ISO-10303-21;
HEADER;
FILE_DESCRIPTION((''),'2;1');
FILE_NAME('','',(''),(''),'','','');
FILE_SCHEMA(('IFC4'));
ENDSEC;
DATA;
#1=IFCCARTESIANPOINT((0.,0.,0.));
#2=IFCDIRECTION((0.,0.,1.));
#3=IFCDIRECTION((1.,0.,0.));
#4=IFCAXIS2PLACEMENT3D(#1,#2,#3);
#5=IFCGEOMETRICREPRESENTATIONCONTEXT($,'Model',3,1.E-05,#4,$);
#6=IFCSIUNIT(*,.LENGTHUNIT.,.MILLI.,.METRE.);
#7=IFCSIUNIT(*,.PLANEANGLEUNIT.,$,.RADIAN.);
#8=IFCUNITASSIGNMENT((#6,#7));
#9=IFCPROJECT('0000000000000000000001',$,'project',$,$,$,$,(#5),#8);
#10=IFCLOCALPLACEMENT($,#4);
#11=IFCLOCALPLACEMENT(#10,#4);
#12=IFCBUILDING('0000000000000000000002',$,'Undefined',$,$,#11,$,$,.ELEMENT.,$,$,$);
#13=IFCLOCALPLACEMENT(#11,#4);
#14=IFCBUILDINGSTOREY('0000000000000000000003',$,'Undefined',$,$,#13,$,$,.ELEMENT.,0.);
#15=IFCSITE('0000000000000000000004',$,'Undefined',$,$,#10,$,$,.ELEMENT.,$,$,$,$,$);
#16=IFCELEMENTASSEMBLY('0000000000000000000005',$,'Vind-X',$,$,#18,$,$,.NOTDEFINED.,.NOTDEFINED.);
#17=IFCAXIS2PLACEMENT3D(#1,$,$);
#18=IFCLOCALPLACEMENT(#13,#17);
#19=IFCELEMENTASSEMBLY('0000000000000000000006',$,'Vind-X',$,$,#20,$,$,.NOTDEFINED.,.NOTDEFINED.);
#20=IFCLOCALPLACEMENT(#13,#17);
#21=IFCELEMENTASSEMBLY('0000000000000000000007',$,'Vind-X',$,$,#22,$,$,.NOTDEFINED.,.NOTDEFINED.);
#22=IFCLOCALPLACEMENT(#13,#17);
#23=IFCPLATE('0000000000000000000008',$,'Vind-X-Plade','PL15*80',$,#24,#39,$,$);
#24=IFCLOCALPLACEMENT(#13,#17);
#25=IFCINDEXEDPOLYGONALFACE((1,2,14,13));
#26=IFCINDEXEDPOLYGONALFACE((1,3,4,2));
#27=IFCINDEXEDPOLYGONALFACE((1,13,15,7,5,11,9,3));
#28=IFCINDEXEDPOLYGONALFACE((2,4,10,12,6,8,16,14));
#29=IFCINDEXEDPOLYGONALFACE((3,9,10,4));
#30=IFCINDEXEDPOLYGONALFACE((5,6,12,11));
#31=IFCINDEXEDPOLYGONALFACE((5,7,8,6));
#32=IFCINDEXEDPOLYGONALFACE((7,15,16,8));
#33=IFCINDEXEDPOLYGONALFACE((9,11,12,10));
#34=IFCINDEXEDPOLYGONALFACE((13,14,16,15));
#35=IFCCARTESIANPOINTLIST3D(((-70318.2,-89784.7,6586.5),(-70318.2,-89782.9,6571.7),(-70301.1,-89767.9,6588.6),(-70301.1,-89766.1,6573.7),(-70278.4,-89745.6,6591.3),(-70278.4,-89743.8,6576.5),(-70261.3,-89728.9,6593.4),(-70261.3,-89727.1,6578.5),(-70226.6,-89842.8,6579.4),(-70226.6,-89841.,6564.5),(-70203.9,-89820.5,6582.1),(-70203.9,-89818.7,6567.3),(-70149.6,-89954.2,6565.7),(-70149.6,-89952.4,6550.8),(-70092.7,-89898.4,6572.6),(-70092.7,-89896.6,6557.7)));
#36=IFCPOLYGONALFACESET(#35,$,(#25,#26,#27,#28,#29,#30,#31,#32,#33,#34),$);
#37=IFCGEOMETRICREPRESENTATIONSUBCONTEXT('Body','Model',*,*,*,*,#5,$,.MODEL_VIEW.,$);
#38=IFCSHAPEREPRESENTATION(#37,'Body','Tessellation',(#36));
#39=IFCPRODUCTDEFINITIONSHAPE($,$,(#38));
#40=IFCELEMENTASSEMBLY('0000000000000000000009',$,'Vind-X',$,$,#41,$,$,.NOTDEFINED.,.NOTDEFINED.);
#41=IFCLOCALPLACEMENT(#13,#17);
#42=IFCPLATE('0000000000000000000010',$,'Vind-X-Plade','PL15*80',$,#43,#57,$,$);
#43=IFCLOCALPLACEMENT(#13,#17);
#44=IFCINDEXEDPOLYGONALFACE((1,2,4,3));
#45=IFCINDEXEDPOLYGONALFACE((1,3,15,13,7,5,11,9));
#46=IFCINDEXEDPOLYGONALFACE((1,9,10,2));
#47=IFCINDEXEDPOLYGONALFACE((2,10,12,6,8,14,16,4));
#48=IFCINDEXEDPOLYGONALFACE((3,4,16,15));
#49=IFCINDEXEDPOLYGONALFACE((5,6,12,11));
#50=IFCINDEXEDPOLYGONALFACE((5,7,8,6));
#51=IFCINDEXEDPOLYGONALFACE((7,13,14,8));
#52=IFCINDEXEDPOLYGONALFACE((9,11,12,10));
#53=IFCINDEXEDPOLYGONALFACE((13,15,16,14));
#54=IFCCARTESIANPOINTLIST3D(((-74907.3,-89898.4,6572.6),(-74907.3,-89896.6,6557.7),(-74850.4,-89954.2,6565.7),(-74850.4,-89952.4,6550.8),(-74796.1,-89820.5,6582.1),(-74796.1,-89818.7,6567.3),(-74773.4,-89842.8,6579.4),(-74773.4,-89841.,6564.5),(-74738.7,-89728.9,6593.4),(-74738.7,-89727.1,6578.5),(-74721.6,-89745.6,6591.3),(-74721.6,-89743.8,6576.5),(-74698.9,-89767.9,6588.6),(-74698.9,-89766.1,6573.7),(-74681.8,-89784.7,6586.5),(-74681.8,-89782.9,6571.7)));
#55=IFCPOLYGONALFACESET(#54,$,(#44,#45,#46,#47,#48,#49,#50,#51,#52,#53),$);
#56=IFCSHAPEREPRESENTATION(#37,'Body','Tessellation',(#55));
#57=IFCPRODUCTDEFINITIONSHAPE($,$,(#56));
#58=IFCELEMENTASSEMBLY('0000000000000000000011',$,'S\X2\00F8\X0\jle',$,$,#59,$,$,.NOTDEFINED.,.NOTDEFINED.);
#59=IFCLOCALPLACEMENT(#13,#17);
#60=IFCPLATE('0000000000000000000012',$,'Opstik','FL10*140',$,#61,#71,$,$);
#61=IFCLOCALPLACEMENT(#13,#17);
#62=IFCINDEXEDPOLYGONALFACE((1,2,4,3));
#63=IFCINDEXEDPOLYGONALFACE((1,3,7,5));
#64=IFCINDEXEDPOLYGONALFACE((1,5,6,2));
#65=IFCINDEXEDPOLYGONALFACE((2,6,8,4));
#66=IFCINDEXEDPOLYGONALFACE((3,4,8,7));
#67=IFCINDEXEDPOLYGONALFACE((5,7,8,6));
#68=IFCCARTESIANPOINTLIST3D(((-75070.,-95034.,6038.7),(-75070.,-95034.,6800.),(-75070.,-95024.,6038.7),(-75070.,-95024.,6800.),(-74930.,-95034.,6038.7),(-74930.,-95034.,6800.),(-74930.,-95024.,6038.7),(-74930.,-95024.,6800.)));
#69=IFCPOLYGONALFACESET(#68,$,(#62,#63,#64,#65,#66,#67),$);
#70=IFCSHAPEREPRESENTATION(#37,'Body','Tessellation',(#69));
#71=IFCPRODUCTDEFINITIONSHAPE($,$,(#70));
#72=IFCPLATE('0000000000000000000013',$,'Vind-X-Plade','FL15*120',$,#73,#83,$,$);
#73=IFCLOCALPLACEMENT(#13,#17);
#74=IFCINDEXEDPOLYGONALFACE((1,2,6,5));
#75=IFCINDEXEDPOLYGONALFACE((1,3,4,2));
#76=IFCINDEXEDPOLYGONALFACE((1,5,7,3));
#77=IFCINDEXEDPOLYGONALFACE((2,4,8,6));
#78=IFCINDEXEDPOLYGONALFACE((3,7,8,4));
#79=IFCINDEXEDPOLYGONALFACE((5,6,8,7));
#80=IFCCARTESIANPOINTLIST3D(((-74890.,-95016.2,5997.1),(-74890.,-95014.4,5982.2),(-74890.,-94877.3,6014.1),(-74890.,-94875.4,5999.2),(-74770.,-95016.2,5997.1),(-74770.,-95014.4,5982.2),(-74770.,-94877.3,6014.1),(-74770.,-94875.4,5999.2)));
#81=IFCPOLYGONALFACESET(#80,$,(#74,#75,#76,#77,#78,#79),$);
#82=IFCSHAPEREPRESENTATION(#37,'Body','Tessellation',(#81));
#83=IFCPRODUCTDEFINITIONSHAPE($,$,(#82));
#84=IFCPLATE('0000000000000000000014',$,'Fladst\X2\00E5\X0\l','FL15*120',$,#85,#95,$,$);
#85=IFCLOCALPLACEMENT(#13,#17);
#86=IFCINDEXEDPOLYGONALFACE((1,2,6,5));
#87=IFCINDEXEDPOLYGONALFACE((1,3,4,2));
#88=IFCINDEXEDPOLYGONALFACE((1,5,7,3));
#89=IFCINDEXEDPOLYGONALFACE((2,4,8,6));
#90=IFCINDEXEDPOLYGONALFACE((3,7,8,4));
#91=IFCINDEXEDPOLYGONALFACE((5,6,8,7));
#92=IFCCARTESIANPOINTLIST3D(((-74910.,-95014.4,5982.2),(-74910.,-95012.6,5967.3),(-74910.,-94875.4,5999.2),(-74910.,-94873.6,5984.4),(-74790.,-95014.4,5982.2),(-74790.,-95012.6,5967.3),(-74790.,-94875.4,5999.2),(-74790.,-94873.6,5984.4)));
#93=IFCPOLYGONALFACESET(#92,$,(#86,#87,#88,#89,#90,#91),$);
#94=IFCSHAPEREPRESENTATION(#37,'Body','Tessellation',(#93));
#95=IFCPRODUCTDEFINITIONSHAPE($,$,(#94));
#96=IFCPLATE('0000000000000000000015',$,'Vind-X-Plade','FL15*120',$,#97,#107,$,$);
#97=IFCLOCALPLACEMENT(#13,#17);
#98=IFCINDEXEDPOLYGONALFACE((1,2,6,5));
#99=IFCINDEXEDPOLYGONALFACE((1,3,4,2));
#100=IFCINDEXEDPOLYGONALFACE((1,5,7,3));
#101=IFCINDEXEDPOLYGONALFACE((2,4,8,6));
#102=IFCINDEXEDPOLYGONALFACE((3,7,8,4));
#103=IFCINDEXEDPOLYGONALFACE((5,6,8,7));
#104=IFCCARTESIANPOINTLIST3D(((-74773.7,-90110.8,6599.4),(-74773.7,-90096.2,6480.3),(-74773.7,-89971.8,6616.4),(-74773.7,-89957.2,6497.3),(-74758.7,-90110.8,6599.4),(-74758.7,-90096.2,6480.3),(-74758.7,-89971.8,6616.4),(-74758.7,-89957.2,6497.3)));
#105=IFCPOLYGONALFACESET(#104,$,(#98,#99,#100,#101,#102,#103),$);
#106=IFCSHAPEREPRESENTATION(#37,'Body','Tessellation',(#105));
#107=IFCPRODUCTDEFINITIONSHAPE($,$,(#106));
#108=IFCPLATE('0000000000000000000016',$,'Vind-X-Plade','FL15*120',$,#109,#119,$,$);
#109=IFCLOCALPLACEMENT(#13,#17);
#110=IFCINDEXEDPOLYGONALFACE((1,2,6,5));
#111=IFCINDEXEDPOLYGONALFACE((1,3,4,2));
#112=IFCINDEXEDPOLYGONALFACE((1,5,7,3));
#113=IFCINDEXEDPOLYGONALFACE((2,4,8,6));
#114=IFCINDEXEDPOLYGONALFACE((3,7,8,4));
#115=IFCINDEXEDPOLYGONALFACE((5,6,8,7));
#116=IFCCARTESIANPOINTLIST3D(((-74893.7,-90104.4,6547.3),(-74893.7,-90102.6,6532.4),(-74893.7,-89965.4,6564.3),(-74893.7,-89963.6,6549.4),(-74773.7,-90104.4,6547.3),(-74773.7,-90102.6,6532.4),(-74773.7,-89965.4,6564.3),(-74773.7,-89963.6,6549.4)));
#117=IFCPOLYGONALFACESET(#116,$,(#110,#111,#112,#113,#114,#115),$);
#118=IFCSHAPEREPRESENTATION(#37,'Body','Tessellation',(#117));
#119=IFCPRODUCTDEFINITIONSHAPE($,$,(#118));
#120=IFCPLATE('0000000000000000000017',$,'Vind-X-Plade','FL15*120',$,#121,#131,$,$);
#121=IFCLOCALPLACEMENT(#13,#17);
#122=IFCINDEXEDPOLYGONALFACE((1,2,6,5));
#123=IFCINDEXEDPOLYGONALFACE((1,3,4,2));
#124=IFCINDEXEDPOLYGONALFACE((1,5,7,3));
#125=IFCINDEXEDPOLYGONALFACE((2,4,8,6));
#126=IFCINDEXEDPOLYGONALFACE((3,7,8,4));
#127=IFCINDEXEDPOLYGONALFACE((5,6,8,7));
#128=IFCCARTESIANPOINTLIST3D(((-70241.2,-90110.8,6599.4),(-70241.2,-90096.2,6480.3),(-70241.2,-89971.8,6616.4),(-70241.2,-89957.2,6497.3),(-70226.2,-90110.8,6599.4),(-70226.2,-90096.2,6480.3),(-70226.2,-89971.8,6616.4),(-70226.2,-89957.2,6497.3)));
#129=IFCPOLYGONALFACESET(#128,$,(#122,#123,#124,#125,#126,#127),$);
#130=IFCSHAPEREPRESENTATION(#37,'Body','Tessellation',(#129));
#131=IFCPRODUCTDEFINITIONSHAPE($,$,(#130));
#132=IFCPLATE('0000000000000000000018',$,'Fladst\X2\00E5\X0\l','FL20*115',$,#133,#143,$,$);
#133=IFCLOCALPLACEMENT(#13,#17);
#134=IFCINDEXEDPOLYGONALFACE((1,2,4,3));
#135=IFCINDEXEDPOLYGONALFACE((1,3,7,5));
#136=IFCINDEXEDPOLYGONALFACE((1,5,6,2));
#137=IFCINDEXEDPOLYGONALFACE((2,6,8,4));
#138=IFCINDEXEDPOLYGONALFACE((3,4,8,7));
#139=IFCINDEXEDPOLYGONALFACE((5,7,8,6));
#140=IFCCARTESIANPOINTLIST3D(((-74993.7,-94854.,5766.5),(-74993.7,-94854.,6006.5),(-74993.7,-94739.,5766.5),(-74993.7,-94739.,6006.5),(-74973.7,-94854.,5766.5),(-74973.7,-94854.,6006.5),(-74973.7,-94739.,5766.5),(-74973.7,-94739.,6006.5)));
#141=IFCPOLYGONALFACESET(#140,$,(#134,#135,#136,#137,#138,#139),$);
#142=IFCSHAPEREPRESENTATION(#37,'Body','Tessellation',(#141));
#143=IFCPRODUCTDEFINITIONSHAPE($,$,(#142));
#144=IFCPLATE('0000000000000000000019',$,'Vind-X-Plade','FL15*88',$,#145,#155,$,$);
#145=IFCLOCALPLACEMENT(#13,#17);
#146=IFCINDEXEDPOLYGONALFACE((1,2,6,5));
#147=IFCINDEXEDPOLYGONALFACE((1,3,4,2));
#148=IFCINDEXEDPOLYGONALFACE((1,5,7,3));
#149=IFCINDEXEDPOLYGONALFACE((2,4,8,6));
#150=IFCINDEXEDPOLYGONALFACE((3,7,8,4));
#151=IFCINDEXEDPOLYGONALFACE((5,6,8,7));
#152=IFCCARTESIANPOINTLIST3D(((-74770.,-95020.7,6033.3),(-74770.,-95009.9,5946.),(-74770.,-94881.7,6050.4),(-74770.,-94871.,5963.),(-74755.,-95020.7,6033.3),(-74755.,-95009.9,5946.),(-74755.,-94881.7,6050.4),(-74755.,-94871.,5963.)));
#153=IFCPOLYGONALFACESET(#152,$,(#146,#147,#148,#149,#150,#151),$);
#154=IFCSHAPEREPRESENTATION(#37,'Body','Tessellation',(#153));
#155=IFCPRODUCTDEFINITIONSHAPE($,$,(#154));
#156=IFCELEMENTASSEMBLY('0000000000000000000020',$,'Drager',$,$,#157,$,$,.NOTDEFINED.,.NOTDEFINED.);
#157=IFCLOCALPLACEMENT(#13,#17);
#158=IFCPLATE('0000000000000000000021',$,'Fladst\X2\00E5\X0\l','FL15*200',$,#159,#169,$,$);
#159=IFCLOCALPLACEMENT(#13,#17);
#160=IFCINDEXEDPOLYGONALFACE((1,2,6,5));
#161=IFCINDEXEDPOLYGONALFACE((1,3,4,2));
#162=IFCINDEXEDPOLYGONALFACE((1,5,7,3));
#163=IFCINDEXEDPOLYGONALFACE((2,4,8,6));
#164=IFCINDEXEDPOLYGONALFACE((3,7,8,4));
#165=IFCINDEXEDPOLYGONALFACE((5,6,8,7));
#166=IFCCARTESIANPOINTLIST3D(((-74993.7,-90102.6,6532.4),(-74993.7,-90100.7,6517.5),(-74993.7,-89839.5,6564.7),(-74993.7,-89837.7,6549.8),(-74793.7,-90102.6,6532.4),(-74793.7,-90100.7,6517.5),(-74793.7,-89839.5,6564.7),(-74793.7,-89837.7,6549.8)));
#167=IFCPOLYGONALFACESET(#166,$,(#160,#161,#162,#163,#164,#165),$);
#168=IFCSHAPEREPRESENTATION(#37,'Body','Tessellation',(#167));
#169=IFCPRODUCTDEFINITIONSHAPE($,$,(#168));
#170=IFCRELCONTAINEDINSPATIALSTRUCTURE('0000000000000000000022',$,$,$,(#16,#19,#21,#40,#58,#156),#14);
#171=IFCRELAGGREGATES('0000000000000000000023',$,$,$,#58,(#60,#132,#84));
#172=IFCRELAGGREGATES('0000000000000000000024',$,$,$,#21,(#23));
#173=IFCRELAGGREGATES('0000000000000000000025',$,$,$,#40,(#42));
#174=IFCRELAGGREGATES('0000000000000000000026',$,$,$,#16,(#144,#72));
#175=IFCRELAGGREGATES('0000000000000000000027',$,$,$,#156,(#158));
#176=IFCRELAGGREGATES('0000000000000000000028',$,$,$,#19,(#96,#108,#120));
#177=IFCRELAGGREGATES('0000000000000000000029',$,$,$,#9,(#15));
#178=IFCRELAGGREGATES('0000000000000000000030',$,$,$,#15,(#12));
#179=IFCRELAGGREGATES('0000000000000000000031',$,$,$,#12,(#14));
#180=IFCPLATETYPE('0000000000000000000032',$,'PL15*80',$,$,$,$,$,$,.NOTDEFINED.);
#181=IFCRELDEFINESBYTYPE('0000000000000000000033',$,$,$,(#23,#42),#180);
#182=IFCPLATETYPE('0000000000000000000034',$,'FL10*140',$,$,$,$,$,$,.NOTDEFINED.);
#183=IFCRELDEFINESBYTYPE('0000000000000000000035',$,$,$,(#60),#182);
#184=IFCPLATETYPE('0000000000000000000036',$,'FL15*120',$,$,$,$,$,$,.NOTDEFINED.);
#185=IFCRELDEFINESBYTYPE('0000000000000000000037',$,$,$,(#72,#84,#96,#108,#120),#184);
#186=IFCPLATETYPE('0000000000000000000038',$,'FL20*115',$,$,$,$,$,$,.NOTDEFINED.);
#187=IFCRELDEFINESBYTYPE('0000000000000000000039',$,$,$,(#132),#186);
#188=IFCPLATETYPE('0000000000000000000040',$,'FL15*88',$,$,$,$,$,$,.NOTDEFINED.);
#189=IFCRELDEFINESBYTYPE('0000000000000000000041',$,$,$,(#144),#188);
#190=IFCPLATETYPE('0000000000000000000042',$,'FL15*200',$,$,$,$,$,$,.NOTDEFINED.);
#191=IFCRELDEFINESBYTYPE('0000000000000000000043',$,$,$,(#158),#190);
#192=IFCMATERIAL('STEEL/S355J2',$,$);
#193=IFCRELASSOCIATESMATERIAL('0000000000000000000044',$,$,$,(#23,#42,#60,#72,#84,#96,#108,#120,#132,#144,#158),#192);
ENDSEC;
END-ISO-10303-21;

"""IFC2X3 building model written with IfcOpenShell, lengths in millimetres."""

from ifc_helpers import new_model, si_unit, frame, origin_with_axes, place, context, subcontext, project, spatial, polyline, outline, extrude, boolean, material, type_object, element, aggregate, save


model = new_model("IFC2X3")

# Units and contexts
model_context = context("Model", 3, precision=1e-05, world=origin_with_axes())
body_context = subcontext(model_context, "Body", "Model", "MODEL_VIEW")
ifc_project = project(units=[si_unit("LENGTHUNIT", "METRE", prefix="MILLI"), si_unit("PLANEANGLEUNIT", "RADIAN")], contexts=[model_context])

# Site, building, storey
site_placement = place(None, origin_with_axes())
site = spatial("IfcSite", under=ifc_project, at=site_placement, Name="Undefined", CompositionType="ELEMENT")
building_placement = place(site_placement, origin_with_axes())
building = spatial("IfcBuilding", under=site, at=building_placement, Name="Undefined", CompositionType="ELEMENT")
storey_placement = place(building_placement, origin_with_axes())
storey = spatial("IfcBuildingStorey", under=building, at=storey_placement, Name="Undefined", CompositionType="ELEMENT", Elevation=0.0)

# Element assemblies
assembly_1_placement = place(storey_placement, origin_with_axes())
assembly_1 = element("IfcElementAssembly", 1, at=assembly_1_placement, inside=storey, Name="Vind-X", AssemblyPlace="NOTDEFINED", PredefinedType="NOTDEFINED")
assembly_2_placement = place(storey_placement, origin_with_axes())
assembly_2 = element("IfcElementAssembly", 2, at=assembly_2_placement, inside=storey, Name="Vind-X", AssemblyPlace="NOTDEFINED", PredefinedType="NOTDEFINED")

# Element assemblies, plates
assembly_3_placement = place(storey_placement, origin_with_axes())
assembly_3 = element("IfcElementAssembly", 3, at=assembly_3_placement, inside=storey, Name="Vind-X", AssemblyPlace="NOTDEFINED", PredefinedType="NOTDEFINED")
ifc_material_1 = material(Name="STEEL/S355J2")
plate_type_1 = type_object("IfcPlateType", Name="PL15*80", PredefinedType="NOTDEFINED")
plate_1_placement = place(assembly_3_placement, frame((-70149.6, -89953.3, 6558.3), z_axis=(0.0, -0.121869, 0.992546), x_axis=(0.711592, 0.697356, 0.085625)))
plate_1 = element("IfcPlate", 4, at=plate_1_placement, type_object=plate_type_1, material=ifc_material_1, Name="Vind-X-Plade", Description="PL15*80", context=body_context, shape_type="CSG", body=[
    boolean("DIFFERENCE", extrude(outline(polyline([(0.0, 0.0), (80.0, 0.0), (80.0, 240.0), (0.0, 240.0), (0.0, 0.0)])), frame((0.0, 0.0, -7.5), z_axis=(0.0, 0.0, 1.0), x_axis=(1.0, 0.0, 0.0)), (0.0, 0.0, 1.0), 15.0), extrude(outline(polyline([(0.0, 0.0), (106.0, 0.0), (106.0, 32.0), (0.0, 32.0), (0.0, 0.0)])), frame((56.0, 240.0, 8.5), z_axis=(0.0, 0.0, -1.0), x_axis=(0.0, -1.0, 0.0)), (0.0, 0.0, 1.0), 17.0)),
])
assembly_4_placement = place(storey_placement, origin_with_axes())
assembly_4 = element("IfcElementAssembly", 5, at=assembly_4_placement, inside=storey, Name="Vind-X", AssemblyPlace="NOTDEFINED", PredefinedType="NOTDEFINED")
plate_2_placement = place(assembly_4_placement, frame((-74850.4, -89953.3, 6558.3), z_axis=(0.0, 0.121869, -0.992546), x_axis=(-0.711592, 0.697356, 0.085625)))
plate_2 = element("IfcPlate", 6, at=plate_2_placement, type_object=plate_type_1, material=ifc_material_1, Name="Vind-X-Plade", Description="PL15*80", context=body_context, shape_type="CSG", body=[
    boolean("DIFFERENCE", extrude(outline(polyline([(0.0, 0.0), (80.0, 0.0), (80.0, 240.0), (0.0, 240.0), (0.0, 0.0)])), frame((0.0, 0.0, -7.5), z_axis=(0.0, 0.0, 1.0), x_axis=(1.0, 0.0, 0.0)), (0.0, 0.0, 1.0), 15.0), extrude(outline(polyline([(0.0, 0.0), (106.0, 0.0), (106.0, 32.0), (0.0, 32.0), (0.0, 0.0)])), frame((56.0, 240.0, 8.5), z_axis=(0.0, 0.0, -1.0), x_axis=(0.0, -1.0, 0.0)), (0.0, 0.0, 1.0), 17.0)),
])
assembly_5_placement = place(storey_placement, origin_with_axes())
assembly_5 = element("IfcElementAssembly", 7, at=assembly_5_placement, inside=storey, Name="Søjle", AssemblyPlace="NOTDEFINED", PredefinedType="NOTDEFINED")
plate_type_2 = type_object("IfcPlateType", Name="FL10*140", PredefinedType="NOTDEFINED")
plate_3_placement = place(assembly_5_placement, frame((-74930.0, -95029.0, 6038.7), z_axis=(0.0, -1.0, 0.0), x_axis=(0.0, 0.0, 1.0)))
plate_3 = element("IfcPlate", 8, at=plate_3_placement, type_object=plate_type_2, material=ifc_material_1, Name="Opstik", Description="FL10*140", context=body_context, shape_type="SweptSolid", body=[
    extrude(outline(polyline([(0.0, 0.0), (761.3, 0.0), (761.3, 0.0), (761.3, 140.0), (761.3, 140.0), (0.0, 140.0), (0.0, 0.0)])), frame((0.0, 0.0, -5.0), z_axis=(0.0, 0.0, 1.0), x_axis=(1.0, 0.0, 0.0)), (0.0, 0.0, 1.0), 10.0),
])

# Plates
plate_type_3 = type_object("IfcPlateType", Name="FL15*120", PredefinedType="NOTDEFINED")
plate_4_placement = place(assembly_1_placement, frame((-74890.0, -94945.8, 5998.2), z_axis=(0.0, 0.121869, -0.992546), x_axis=(1.0, 0.0, 0.0)))
plate_4 = element("IfcPlate", 9, at=plate_4_placement, type_object=plate_type_3, material=ifc_material_1, Name="Vind-X-Plade", Description="FL15*120", context=body_context, shape_type="SweptSolid", body=[
    extrude(outline(polyline([(0.0, -70.0), (0.0, 70.0), (120.0, 70.0), (120.0, -70.0), (0.0, -70.0)])), frame((0.0, 0.0, -7.5), z_axis=(0.0, 0.0, 1.0), x_axis=(1.0, 0.0, 0.0)), (0.0, 0.0, 1.0), 15.0),
])
plate_5_placement = place(assembly_5_placement, frame((-74910.0, -94874.5, 5991.8), z_axis=(0.0, -0.121869, 0.992546), x_axis=(0.0, -0.992546, -0.121869)))
plate_5 = element("IfcPlate", 10, at=plate_5_placement, type_object=plate_type_3, material=ifc_material_1, Name="Fladstål", Description="FL15*120", context=body_context, shape_type="SweptSolid", body=[
    extrude(outline(polyline([(0.0, 0.0), (140.0, 0.0), (140.0, 120.0), (0.0, 120.0), (0.0, 0.0)])), frame((0.0, 0.0, -7.5), z_axis=(0.0, 0.0, 1.0), x_axis=(1.0, 0.0, 0.0)), (0.0, 0.0, 1.0), 15.0),
])
plate_6_placement = place(assembly_2_placement, frame((-74766.2, -89957.2, 6497.3), z_axis=(-1.0, 0.0, 0.0), x_axis=(0.0, -0.992546, -0.121869)))
plate_6 = element("IfcPlate", 11, at=plate_6_placement, type_object=plate_type_3, material=ifc_material_1, Name="Vind-X-Plade", Description="FL15*120", context=body_context, shape_type="SweptSolid", body=[
    extrude(outline(polyline([(0.0, 0.0), (140.0, 0.0), (140.0, 120.0), (0.0, 120.0), (0.0, 0.0)])), frame((0.0, 0.0, -7.5), z_axis=(0.0, 0.0, 1.0), x_axis=(1.0, 0.0, 0.0)), (0.0, 0.0, 1.0), 15.0),
])
plate_7_placement = place(assembly_2_placement, frame((-74893.7, -90034.0, 6548.4), z_axis=(0.0, 0.121869, -0.992546), x_axis=(1.0, 0.0, 0.0)))
plate_7 = element("IfcPlate", 12, at=plate_7_placement, type_object=plate_type_3, material=ifc_material_1, Name="Vind-X-Plade", Description="FL15*120", context=body_context, shape_type="SweptSolid", body=[
    extrude(outline(polyline([(0.0, -70.0), (0.0, 70.0), (120.0, 70.0), (120.0, -70.0), (0.0, -70.0)])), frame((0.0, 0.0, -7.5), z_axis=(0.0, 0.0, 1.0), x_axis=(1.0, 0.0, 0.0)), (0.0, 0.0, 1.0), 15.0),
])
plate_8_placement = place(assembly_2_placement, frame((-70233.7, -90096.2, 6480.3), z_axis=(1.0, 0.0, 0.0), x_axis=(0.0, 0.992546, 0.121869)))
plate_8 = element("IfcPlate", 13, at=plate_8_placement, type_object=plate_type_3, material=ifc_material_1, Name="Vind-X-Plade", Description="FL15*120", context=body_context, shape_type="SweptSolid", body=[
    extrude(outline(polyline([(0.0, 0.0), (140.0, 0.0), (140.0, 120.0), (0.0, 120.0), (0.0, 0.0)])), frame((0.0, 0.0, -7.5), z_axis=(0.0, 0.0, 1.0), x_axis=(1.0, 0.0, 0.0)), (0.0, 0.0, 1.0), 15.0),
])
plate_type_4 = type_object("IfcPlateType", Name="FL20*115", PredefinedType="NOTDEFINED")
plate_9_placement = place(assembly_5_placement, frame((-74983.7, -94854.0, 6006.5), z_axis=(1.0, 0.0, 0.0), x_axis=(0.0, 0.0, -1.0)))
plate_9 = element("IfcPlate", 14, at=plate_9_placement, type_object=plate_type_4, material=ifc_material_1, Name="Fladstål", Description="FL20*115", context=body_context, shape_type="SweptSolid", body=[
    extrude(outline(polyline([(0.0, 0.0), (240.0, 0.0), (240.0, 115.0), (0.0, 115.0), (0.0, 0.0)])), frame((0.0, 0.0, -10.0), z_axis=(0.0, 0.0, 1.0), x_axis=(1.0, 0.0, 0.0)), (0.0, 0.0, 1.0), 20.0),
])
aggregate(assembly_5, [plate_3, plate_9, plate_5])
plate_type_5 = type_object("IfcPlateType", Name="FL15*88", PredefinedType="NOTDEFINED")
plate_10_placement = place(assembly_1_placement, frame((-74762.5, -94871.0, 5963.0), z_axis=(-1.0, 0.0, 0.0), x_axis=(0.0, -0.992546, -0.121869)))
plate_10 = element("IfcPlate", 15, at=plate_10_placement, type_object=plate_type_5, material=ifc_material_1, Name="Vind-X-Plade", Description="FL15*88", context=body_context, shape_type="SweptSolid", body=[
    extrude(outline(polyline([(0.0, 0.0), (140.0, 0.0), (140.0, 88.0), (0.0, 88.0), (0.0, 0.0)])), frame((0.0, 0.0, -7.5), z_axis=(0.0, 0.0, 1.0), x_axis=(1.0, 0.0, 0.0)), (0.0, 0.0, 1.0), 15.0),
])

# Element assembly, plate
assembly_6_placement = place(storey_placement, origin_with_axes())
assembly_6 = element("IfcElementAssembly", 16, at=assembly_6_placement, inside=storey, Name="Drager", AssemblyPlace="NOTDEFINED", PredefinedType="NOTDEFINED")
plate_type_6 = type_object("IfcPlateType", Name="FL15*200", PredefinedType="NOTDEFINED")
plate_11_placement = place(assembly_6_placement, frame((-74993.7, -89838.6, 6557.2), z_axis=(0.0, -0.121869, 0.992546), x_axis=(0.0, -0.992546, -0.121869)))
plate_11 = element("IfcPlate", 17, at=plate_11_placement, type_object=plate_type_6, material=ifc_material_1, Name="Fladstål", Description="FL15*200", context=body_context, shape_type="SweptSolid", body=[
    extrude(outline(polyline([(0.0, 0.0), (265.0, 0.0), (265.0, 200.0), (0.0, 200.0), (0.0, 0.0)])), frame((0.0, 0.0, -7.5), z_axis=(0.0, 0.0, 1.0), x_axis=(1.0, 0.0, 0.0)), (0.0, 0.0, 1.0), 15.0),
])

aggregate(assembly_3, [plate_1])
aggregate(assembly_4, [plate_2])
aggregate(assembly_1, [plate_10, plate_4])

aggregate(assembly_6, [plate_11])
aggregate(assembly_2, [plate_6, plate_7, plate_8])

save(model, "model.ifc")
